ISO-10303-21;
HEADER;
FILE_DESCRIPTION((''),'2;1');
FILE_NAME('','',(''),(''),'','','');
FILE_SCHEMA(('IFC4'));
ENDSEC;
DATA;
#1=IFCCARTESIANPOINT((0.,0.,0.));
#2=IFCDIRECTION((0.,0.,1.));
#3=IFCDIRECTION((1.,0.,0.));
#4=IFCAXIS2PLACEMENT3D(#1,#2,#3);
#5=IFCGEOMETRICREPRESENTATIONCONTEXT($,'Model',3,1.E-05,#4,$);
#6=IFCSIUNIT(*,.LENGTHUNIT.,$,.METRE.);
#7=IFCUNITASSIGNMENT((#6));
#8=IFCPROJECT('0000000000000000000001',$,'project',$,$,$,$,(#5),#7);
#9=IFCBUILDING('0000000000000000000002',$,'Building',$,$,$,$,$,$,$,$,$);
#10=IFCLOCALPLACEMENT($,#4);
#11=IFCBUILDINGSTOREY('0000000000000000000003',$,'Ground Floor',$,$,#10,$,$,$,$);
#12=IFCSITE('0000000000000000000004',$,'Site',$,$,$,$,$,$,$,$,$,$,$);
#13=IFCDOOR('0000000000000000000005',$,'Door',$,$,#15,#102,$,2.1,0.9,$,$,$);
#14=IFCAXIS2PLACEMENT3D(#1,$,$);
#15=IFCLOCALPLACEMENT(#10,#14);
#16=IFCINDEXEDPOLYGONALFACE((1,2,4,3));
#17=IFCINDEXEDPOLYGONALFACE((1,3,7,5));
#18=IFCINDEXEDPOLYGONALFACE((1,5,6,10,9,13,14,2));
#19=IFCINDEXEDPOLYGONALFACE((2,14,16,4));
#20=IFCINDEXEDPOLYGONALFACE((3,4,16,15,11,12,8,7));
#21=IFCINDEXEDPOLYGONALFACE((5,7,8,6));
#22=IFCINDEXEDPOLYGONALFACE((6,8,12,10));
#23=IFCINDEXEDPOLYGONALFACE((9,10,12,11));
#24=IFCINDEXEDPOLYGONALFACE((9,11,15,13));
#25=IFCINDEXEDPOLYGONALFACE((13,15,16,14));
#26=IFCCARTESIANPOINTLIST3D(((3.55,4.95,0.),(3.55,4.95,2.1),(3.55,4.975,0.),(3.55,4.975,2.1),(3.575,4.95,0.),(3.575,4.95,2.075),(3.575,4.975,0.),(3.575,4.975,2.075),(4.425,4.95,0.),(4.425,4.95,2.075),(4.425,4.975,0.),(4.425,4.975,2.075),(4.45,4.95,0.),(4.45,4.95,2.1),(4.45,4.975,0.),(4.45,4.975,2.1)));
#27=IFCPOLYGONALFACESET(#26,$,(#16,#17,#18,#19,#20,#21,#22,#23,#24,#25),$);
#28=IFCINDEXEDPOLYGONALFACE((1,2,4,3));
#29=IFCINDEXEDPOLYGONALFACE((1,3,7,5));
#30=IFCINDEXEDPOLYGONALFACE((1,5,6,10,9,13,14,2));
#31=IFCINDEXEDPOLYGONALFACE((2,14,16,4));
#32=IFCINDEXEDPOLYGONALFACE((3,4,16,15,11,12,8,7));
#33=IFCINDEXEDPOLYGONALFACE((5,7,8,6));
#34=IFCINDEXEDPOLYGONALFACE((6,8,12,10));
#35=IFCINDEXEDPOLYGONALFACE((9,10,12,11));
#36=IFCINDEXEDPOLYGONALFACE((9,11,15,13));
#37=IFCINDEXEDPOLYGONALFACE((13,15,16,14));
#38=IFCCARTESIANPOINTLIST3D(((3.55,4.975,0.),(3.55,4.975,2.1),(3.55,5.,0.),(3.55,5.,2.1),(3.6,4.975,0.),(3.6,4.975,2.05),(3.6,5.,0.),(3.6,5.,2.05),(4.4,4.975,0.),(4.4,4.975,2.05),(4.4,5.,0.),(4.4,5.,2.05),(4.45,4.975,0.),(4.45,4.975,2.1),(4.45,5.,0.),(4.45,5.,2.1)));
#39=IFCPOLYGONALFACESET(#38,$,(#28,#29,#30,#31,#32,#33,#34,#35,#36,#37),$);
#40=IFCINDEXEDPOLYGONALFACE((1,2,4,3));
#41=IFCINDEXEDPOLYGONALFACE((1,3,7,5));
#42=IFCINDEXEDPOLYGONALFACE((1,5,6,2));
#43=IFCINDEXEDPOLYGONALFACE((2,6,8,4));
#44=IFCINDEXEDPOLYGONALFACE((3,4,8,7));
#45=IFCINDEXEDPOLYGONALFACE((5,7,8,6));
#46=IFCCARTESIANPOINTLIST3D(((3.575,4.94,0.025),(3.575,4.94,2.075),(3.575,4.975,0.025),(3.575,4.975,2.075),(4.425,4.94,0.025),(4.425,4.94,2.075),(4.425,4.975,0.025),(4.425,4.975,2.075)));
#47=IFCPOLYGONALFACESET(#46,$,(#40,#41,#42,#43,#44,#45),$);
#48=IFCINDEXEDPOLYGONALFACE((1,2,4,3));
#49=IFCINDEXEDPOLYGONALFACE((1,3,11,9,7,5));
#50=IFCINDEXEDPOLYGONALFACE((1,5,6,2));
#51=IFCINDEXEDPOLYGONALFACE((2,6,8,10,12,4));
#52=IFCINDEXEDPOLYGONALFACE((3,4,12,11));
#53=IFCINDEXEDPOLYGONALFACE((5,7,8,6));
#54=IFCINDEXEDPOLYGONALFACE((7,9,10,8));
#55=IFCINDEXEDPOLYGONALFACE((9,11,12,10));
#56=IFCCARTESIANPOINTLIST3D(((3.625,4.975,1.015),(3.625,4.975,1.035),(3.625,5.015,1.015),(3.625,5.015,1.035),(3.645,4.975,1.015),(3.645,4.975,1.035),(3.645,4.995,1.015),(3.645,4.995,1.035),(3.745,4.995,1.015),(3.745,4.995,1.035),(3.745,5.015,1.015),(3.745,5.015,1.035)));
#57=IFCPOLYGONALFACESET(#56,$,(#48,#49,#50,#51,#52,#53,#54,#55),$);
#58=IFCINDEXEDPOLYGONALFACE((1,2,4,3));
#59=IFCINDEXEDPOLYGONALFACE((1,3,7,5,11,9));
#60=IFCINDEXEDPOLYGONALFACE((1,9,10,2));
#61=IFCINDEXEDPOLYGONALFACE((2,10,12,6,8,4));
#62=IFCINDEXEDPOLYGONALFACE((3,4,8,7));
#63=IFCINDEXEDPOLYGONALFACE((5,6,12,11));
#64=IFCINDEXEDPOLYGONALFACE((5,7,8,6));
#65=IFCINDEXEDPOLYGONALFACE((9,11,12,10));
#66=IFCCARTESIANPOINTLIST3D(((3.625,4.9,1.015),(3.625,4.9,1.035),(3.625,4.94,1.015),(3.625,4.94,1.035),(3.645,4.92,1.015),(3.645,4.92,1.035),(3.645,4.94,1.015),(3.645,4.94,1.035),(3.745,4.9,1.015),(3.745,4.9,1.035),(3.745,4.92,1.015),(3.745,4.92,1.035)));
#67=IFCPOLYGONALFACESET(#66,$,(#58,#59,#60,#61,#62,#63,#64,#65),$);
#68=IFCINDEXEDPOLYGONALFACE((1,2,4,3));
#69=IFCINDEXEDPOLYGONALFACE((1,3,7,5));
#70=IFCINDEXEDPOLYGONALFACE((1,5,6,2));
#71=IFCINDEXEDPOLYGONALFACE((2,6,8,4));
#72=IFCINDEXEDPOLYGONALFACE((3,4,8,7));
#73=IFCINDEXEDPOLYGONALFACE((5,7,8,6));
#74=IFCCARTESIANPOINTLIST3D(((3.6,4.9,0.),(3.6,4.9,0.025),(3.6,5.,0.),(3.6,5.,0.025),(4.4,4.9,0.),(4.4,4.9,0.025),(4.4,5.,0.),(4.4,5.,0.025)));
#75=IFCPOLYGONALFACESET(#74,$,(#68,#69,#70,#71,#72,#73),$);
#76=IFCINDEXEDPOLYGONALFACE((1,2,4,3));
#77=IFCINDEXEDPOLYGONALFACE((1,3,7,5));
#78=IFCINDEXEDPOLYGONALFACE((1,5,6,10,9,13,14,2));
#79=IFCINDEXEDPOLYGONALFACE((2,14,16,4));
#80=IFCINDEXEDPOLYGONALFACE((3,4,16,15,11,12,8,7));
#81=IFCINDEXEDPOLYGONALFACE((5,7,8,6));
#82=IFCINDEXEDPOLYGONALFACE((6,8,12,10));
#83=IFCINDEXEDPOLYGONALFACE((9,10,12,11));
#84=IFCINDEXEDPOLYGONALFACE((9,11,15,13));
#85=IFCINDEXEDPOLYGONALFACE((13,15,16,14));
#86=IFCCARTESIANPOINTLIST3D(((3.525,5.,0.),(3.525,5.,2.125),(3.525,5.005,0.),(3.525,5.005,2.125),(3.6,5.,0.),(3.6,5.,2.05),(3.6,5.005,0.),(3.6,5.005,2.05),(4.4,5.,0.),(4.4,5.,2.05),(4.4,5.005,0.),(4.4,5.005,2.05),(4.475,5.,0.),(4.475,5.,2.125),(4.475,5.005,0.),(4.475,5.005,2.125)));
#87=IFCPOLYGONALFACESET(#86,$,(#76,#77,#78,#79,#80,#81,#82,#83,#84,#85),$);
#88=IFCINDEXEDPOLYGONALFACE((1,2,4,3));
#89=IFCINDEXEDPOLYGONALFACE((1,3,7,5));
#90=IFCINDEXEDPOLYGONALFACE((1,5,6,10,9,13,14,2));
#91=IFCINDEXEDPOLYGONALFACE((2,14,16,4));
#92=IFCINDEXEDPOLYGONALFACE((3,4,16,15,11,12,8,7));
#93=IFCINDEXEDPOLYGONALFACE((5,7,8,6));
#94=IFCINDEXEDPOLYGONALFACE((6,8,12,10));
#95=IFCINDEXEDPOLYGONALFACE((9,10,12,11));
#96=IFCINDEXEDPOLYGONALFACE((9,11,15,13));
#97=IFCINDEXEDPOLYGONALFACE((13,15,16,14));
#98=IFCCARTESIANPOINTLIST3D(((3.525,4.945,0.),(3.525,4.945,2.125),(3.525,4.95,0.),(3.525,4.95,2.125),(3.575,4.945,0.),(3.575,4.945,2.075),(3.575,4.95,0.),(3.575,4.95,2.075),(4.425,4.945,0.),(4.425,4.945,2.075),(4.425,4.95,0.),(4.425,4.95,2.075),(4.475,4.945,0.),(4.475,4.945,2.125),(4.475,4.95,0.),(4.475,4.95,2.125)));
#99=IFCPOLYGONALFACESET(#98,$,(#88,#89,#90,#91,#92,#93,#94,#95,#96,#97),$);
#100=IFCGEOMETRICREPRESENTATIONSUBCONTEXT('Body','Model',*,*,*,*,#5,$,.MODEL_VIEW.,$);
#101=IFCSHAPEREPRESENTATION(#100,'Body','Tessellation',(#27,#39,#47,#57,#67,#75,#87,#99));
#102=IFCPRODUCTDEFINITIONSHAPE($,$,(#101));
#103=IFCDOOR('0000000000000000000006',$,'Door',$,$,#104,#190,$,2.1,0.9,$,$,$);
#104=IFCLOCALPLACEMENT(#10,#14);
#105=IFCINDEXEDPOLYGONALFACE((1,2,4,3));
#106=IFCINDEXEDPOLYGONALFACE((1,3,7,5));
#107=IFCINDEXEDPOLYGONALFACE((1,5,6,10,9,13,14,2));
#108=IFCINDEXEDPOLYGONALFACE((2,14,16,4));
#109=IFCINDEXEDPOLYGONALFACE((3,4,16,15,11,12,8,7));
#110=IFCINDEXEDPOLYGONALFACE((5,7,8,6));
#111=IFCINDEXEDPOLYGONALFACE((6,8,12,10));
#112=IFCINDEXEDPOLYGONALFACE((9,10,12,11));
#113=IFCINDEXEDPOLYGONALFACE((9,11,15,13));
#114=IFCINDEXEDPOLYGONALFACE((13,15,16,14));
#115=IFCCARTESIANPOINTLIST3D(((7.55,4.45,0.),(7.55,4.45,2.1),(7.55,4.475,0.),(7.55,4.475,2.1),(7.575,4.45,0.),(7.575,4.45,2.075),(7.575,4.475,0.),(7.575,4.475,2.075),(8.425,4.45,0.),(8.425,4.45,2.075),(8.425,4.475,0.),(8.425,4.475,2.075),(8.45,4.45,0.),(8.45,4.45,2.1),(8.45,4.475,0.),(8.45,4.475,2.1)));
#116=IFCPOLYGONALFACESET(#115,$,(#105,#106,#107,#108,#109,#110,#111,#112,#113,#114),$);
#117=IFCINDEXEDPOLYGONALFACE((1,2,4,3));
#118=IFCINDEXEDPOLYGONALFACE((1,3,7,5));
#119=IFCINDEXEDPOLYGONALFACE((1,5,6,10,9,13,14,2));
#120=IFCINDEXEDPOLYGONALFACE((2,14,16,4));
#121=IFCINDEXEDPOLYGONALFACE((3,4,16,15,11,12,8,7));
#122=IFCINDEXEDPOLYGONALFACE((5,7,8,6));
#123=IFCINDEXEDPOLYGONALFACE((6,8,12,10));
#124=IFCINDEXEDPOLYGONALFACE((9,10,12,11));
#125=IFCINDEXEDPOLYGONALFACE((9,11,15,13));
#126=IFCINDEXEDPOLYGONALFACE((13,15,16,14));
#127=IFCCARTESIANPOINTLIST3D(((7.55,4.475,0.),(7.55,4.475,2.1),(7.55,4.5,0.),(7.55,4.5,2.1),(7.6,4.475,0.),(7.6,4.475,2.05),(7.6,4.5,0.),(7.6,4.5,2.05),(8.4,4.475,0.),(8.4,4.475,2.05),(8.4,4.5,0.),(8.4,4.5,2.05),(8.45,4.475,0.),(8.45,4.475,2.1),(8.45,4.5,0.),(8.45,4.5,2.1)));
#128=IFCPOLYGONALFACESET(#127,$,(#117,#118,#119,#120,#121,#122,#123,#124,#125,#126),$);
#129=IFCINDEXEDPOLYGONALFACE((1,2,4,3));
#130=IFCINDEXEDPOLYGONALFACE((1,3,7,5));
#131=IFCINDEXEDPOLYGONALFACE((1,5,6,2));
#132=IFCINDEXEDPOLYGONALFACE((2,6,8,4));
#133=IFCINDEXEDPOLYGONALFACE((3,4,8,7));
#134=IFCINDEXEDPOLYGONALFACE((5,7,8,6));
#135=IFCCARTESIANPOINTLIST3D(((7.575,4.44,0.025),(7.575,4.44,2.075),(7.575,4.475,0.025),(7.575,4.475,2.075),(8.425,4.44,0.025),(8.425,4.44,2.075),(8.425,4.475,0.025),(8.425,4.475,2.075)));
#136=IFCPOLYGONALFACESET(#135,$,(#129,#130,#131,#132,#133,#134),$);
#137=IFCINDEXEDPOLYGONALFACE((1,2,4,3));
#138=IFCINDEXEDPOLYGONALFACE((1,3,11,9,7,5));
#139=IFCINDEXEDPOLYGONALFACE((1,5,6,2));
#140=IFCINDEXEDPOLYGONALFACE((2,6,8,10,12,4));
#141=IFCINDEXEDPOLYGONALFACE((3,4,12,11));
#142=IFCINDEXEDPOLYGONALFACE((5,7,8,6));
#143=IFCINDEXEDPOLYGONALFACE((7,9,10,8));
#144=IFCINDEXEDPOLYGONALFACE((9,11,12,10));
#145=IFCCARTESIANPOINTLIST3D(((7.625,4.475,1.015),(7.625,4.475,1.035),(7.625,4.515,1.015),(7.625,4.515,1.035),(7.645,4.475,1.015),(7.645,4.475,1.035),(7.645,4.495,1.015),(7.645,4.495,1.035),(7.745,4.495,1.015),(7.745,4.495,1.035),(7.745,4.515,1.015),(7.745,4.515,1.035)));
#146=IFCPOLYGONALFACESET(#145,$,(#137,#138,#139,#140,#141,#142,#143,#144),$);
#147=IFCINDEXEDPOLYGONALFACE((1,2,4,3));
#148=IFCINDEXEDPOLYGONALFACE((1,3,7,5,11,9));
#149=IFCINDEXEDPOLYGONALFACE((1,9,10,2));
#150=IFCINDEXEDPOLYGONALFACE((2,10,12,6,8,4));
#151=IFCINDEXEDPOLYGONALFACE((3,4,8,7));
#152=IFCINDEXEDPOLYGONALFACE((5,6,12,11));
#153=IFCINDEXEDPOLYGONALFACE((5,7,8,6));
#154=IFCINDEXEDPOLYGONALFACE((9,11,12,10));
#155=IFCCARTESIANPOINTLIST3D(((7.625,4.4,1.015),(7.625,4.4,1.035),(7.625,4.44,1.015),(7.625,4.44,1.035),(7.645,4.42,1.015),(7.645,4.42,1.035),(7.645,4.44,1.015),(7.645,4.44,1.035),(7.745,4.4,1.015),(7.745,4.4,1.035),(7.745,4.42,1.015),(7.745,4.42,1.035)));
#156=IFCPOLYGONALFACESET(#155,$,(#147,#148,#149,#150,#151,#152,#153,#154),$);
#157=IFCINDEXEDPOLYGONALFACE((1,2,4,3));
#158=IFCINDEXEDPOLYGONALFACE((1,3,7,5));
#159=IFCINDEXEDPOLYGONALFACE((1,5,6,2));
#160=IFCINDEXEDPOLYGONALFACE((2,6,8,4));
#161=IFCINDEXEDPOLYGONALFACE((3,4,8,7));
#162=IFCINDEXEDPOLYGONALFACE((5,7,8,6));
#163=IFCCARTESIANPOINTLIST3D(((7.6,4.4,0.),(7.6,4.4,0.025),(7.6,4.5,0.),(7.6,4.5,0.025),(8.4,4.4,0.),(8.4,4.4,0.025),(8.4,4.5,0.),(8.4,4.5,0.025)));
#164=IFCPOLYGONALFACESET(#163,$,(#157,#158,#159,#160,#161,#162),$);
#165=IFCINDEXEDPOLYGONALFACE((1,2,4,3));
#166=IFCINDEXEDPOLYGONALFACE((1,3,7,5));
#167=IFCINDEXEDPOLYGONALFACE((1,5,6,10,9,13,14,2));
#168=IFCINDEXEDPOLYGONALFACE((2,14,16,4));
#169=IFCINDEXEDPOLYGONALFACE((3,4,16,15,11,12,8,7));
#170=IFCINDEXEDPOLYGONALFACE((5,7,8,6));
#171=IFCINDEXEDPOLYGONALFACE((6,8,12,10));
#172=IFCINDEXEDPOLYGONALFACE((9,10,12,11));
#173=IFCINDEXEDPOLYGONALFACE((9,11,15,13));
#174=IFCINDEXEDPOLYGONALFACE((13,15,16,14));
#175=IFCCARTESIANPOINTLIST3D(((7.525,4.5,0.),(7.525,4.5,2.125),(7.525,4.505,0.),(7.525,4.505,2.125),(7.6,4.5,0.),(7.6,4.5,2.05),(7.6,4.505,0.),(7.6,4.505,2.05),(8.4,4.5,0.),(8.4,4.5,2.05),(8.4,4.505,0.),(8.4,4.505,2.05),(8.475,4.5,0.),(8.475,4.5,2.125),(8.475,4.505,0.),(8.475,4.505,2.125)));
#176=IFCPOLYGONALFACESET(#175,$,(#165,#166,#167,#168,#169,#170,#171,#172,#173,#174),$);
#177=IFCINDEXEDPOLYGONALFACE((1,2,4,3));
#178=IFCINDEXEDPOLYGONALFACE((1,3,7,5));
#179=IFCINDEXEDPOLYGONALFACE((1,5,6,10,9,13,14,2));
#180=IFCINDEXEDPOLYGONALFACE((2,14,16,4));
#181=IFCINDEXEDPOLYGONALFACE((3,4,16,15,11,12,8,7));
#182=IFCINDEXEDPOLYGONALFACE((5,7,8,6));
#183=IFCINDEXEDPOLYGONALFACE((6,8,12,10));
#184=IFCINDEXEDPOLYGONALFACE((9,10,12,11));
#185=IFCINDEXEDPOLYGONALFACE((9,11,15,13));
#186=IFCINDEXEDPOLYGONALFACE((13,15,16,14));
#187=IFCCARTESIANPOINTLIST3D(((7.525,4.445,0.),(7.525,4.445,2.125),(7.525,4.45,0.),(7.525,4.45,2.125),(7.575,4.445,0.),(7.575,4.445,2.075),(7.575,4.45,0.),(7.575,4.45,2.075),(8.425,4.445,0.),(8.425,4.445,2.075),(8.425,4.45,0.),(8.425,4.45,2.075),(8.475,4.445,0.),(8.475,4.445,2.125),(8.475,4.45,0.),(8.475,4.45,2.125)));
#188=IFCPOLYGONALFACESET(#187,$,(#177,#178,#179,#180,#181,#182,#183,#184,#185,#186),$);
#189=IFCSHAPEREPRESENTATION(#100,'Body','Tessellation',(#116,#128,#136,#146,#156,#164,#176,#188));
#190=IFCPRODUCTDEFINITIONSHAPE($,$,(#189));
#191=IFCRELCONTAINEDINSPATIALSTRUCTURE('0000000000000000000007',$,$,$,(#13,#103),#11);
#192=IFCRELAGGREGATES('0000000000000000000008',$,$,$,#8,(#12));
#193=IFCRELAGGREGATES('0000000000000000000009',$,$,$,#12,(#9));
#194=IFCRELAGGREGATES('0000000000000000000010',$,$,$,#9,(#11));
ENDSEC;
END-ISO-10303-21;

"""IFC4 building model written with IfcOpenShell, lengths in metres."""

from ifc_helpers import new_model, si_unit, frame, origin_with_axes, place, context, subcontext, project, spatial, line, indexed_curve, outline, extrude, element, save


model = new_model("IFC4")

# Units and contexts
model_context = context("Model", 3, precision=1e-05, world=origin_with_axes())
body_context = subcontext(model_context, "Body", "Model", "MODEL_VIEW")
ifc_project = project(units=[si_unit("LENGTHUNIT", "METRE")], contexts=[model_context])

# Site, building, storey
site = spatial("IfcSite", under=ifc_project, Name="Site")
building = spatial("IfcBuilding", under=site, Name="Building")
storey_placement = place(None, origin_with_axes())
storey = spatial("IfcBuildingStorey", under=building, at=storey_placement, Name="Ground Floor")

# Doors
door_1_placement = place(storey_placement, frame((4.45, 5.0, 0.0), z_axis=(0.0, 0.0, 1.0), x_axis=(-1.0, 0.0, 0.0)))
element("IfcDoor", 1, at=door_1_placement, inside=storey, Name="Door", OverallHeight=2.1, OverallWidth=0.9, context=body_context, shape_type="SweptSolid", body=[
    extrude(outline(indexed_curve([(0.0, 0.0), (0.0, 2.1), (0.9, 2.1), (0.9, 0.0), (0.875, 0.0), (0.875, 2.075), (0.025, 2.075), (0.025, 0.0)], segments=[line(1, 2, 3, 4, 5, 6, 7, 8, 1)])), frame((0.0, 0.025, 0.0), z_axis=(0.0, -1.0, 0.0), x_axis=(1.0, 0.0, 0.0)), (0.0, 0.0, -1.0), 0.025),
    extrude(outline(indexed_curve([(0.0, 0.0), (0.0, 2.1), (0.9, 2.1), (0.9, 0.0), (0.85, 0.0), (0.85, 2.05), (0.05, 2.05), (0.05, 0.0)], segments=[line(1, 2, 3, 4, 5, 6, 7, 8, 1)])), frame((0.0, 0.0, 0.0), z_axis=(0.0, -1.0, 0.0), x_axis=(1.0, 0.0, 0.0)), (0.0, 0.0, -1.0), 0.025),
    extrude(outline(indexed_curve([(0.0, 0.0), (0.85, 0.0), (0.85, 0.035), (0.0, 0.035)], segments=[line(1, 2, 3, 4, 1)])), frame((0.025, 0.025, 0.025), z_axis=(0.0, 0.0, 1.0), x_axis=(1.0, 0.0, 0.0)), (0.0, 0.0, 1.0), 2.05),
    extrude(outline(indexed_curve([(0.0, 0.0), (0.0, -0.04), (-0.12, -0.04), (-0.12, -0.02), (-0.02, -0.02), (-0.02, 0.0)], segments=[line(1, 2, 3, 4, 5, 6, 1)])), frame((0.825, 0.025, 1.015), z_axis=(0.0, 0.0, 1.0), x_axis=(1.0, 0.0, 0.0)), (0.0, 0.0, 1.0), 0.02),
    extrude(outline(indexed_curve([(0.0, 0.0), (0.0, 0.04), (-0.12, 0.04), (-0.12, 0.02), (-0.02, 0.02), (-0.02, 0.0)], segments=[line(1, 2, 3, 4, 5, 6, 1)])), frame((0.825, 0.06, 1.015), z_axis=(0.0, 0.0, 1.0), x_axis=(1.0, 0.0, 0.0)), (0.0, 0.0, 1.0), 0.02),
    extrude(outline(indexed_curve([(0.0, 0.0), (0.8, 0.0), (0.8, 0.1), (0.0, 0.1)], segments=[line(1, 2, 3, 4, 1)])), frame((0.05, 0.0, 0.0), z_axis=(0.0, 0.0, 1.0), x_axis=(1.0, 0.0, 0.0)), (0.0, 0.0, 1.0), 0.025),
    extrude(outline(indexed_curve([(0.0, 0.0), (0.0, 2.125), (0.95, 2.125), (0.95, 0.0), (0.875, 0.0), (0.875, 2.05), (0.075, 2.05), (0.075, 0.0)], segments=[line(1, 2, 3, 4, 5, 6, 7, 8, 1)])), frame((-0.025, -0.005, 0.0), z_axis=(0.0, -1.0, 0.0), x_axis=(1.0, 0.0, 0.0)), (0.0, 0.0, -1.0), 0.005),
    extrude(outline(indexed_curve([(0.0, 0.0), (0.0, 2.125), (0.95, 2.125), (0.95, 0.0), (0.9, 0.0), (0.9, 2.075), (0.05, 2.075), (0.05, 0.0)], segments=[line(1, 2, 3, 4, 5, 6, 7, 8, 1)])), frame((-0.025, 0.05, 0.0), z_axis=(0.0, -1.0, 0.0), x_axis=(1.0, 0.0, 0.0)), (0.0, 0.0, -1.0), 0.005),
])
door_2_placement = place(storey_placement, frame((8.45, 4.5, 0.0), z_axis=(0.0, 0.0, 1.0), x_axis=(-1.0, 0.0, 0.0)))
element("IfcDoor", 2, at=door_2_placement, inside=storey, Name="Door", OverallHeight=2.1, OverallWidth=0.9, context=body_context, shape_type="SweptSolid", body=[
    extrude(outline(indexed_curve([(0.0, 0.0), (0.0, 2.1), (0.9, 2.1), (0.9, 0.0), (0.875, 0.0), (0.875, 2.075), (0.025, 2.075), (0.025, 0.0)], segments=[line(1, 2, 3, 4, 5, 6, 7, 8, 1)])), frame((0.0, 0.025, 0.0), z_axis=(0.0, -1.0, 0.0), x_axis=(1.0, 0.0, 0.0)), (0.0, 0.0, -1.0), 0.025),
    extrude(outline(indexed_curve([(0.0, 0.0), (0.0, 2.1), (0.9, 2.1), (0.9, 0.0), (0.85, 0.0), (0.85, 2.05), (0.05, 2.05), (0.05, 0.0)], segments=[line(1, 2, 3, 4, 5, 6, 7, 8, 1)])), frame((0.0, 0.0, 0.0), z_axis=(0.0, -1.0, 0.0), x_axis=(1.0, 0.0, 0.0)), (0.0, 0.0, -1.0), 0.025),
    extrude(outline(indexed_curve([(0.0, 0.0), (0.85, 0.0), (0.85, 0.035), (0.0, 0.035)], segments=[line(1, 2, 3, 4, 1)])), frame((0.025, 0.025, 0.025), z_axis=(0.0, 0.0, 1.0), x_axis=(1.0, 0.0, 0.0)), (0.0, 0.0, 1.0), 2.05),
    extrude(outline(indexed_curve([(0.0, 0.0), (0.0, -0.04), (-0.12, -0.04), (-0.12, -0.02), (-0.02, -0.02), (-0.02, 0.0)], segments=[line(1, 2, 3, 4, 5, 6, 1)])), frame((0.825, 0.025, 1.015), z_axis=(0.0, 0.0, 1.0), x_axis=(1.0, 0.0, 0.0)), (0.0, 0.0, 1.0), 0.02),
    extrude(outline(indexed_curve([(0.0, 0.0), (0.0, 0.04), (-0.12, 0.04), (-0.12, 0.02), (-0.02, 0.02), (-0.02, 0.0)], segments=[line(1, 2, 3, 4, 5, 6, 1)])), frame((0.825, 0.06, 1.015), z_axis=(0.0, 0.0, 1.0), x_axis=(1.0, 0.0, 0.0)), (0.0, 0.0, 1.0), 0.02),
    extrude(outline(indexed_curve([(0.0, 0.0), (0.8, 0.0), (0.8, 0.1), (0.0, 0.1)], segments=[line(1, 2, 3, 4, 1)])), frame((0.05, 0.0, 0.0), z_axis=(0.0, 0.0, 1.0), x_axis=(1.0, 0.0, 0.0)), (0.0, 0.0, 1.0), 0.025),
    extrude(outline(indexed_curve([(0.0, 0.0), (0.0, 2.125), (0.95, 2.125), (0.95, 0.0), (0.875, 0.0), (0.875, 2.05), (0.075, 2.05), (0.075, 0.0)], segments=[line(1, 2, 3, 4, 5, 6, 7, 8, 1)])), frame((-0.025, -0.005, 0.0), z_axis=(0.0, -1.0, 0.0), x_axis=(1.0, 0.0, 0.0)), (0.0, 0.0, -1.0), 0.005),
    extrude(outline(indexed_curve([(0.0, 0.0), (0.0, 2.125), (0.95, 2.125), (0.95, 0.0), (0.9, 0.0), (0.9, 2.075), (0.05, 2.075), (0.05, 0.0)], segments=[line(1, 2, 3, 4, 5, 6, 7, 8, 1)])), frame((-0.025, 0.05, 0.0), z_axis=(0.0, -1.0, 0.0), x_axis=(1.0, 0.0, 0.0)), (0.0, 0.0, -1.0), 0.005),
])

save(model, "model.ifc")
